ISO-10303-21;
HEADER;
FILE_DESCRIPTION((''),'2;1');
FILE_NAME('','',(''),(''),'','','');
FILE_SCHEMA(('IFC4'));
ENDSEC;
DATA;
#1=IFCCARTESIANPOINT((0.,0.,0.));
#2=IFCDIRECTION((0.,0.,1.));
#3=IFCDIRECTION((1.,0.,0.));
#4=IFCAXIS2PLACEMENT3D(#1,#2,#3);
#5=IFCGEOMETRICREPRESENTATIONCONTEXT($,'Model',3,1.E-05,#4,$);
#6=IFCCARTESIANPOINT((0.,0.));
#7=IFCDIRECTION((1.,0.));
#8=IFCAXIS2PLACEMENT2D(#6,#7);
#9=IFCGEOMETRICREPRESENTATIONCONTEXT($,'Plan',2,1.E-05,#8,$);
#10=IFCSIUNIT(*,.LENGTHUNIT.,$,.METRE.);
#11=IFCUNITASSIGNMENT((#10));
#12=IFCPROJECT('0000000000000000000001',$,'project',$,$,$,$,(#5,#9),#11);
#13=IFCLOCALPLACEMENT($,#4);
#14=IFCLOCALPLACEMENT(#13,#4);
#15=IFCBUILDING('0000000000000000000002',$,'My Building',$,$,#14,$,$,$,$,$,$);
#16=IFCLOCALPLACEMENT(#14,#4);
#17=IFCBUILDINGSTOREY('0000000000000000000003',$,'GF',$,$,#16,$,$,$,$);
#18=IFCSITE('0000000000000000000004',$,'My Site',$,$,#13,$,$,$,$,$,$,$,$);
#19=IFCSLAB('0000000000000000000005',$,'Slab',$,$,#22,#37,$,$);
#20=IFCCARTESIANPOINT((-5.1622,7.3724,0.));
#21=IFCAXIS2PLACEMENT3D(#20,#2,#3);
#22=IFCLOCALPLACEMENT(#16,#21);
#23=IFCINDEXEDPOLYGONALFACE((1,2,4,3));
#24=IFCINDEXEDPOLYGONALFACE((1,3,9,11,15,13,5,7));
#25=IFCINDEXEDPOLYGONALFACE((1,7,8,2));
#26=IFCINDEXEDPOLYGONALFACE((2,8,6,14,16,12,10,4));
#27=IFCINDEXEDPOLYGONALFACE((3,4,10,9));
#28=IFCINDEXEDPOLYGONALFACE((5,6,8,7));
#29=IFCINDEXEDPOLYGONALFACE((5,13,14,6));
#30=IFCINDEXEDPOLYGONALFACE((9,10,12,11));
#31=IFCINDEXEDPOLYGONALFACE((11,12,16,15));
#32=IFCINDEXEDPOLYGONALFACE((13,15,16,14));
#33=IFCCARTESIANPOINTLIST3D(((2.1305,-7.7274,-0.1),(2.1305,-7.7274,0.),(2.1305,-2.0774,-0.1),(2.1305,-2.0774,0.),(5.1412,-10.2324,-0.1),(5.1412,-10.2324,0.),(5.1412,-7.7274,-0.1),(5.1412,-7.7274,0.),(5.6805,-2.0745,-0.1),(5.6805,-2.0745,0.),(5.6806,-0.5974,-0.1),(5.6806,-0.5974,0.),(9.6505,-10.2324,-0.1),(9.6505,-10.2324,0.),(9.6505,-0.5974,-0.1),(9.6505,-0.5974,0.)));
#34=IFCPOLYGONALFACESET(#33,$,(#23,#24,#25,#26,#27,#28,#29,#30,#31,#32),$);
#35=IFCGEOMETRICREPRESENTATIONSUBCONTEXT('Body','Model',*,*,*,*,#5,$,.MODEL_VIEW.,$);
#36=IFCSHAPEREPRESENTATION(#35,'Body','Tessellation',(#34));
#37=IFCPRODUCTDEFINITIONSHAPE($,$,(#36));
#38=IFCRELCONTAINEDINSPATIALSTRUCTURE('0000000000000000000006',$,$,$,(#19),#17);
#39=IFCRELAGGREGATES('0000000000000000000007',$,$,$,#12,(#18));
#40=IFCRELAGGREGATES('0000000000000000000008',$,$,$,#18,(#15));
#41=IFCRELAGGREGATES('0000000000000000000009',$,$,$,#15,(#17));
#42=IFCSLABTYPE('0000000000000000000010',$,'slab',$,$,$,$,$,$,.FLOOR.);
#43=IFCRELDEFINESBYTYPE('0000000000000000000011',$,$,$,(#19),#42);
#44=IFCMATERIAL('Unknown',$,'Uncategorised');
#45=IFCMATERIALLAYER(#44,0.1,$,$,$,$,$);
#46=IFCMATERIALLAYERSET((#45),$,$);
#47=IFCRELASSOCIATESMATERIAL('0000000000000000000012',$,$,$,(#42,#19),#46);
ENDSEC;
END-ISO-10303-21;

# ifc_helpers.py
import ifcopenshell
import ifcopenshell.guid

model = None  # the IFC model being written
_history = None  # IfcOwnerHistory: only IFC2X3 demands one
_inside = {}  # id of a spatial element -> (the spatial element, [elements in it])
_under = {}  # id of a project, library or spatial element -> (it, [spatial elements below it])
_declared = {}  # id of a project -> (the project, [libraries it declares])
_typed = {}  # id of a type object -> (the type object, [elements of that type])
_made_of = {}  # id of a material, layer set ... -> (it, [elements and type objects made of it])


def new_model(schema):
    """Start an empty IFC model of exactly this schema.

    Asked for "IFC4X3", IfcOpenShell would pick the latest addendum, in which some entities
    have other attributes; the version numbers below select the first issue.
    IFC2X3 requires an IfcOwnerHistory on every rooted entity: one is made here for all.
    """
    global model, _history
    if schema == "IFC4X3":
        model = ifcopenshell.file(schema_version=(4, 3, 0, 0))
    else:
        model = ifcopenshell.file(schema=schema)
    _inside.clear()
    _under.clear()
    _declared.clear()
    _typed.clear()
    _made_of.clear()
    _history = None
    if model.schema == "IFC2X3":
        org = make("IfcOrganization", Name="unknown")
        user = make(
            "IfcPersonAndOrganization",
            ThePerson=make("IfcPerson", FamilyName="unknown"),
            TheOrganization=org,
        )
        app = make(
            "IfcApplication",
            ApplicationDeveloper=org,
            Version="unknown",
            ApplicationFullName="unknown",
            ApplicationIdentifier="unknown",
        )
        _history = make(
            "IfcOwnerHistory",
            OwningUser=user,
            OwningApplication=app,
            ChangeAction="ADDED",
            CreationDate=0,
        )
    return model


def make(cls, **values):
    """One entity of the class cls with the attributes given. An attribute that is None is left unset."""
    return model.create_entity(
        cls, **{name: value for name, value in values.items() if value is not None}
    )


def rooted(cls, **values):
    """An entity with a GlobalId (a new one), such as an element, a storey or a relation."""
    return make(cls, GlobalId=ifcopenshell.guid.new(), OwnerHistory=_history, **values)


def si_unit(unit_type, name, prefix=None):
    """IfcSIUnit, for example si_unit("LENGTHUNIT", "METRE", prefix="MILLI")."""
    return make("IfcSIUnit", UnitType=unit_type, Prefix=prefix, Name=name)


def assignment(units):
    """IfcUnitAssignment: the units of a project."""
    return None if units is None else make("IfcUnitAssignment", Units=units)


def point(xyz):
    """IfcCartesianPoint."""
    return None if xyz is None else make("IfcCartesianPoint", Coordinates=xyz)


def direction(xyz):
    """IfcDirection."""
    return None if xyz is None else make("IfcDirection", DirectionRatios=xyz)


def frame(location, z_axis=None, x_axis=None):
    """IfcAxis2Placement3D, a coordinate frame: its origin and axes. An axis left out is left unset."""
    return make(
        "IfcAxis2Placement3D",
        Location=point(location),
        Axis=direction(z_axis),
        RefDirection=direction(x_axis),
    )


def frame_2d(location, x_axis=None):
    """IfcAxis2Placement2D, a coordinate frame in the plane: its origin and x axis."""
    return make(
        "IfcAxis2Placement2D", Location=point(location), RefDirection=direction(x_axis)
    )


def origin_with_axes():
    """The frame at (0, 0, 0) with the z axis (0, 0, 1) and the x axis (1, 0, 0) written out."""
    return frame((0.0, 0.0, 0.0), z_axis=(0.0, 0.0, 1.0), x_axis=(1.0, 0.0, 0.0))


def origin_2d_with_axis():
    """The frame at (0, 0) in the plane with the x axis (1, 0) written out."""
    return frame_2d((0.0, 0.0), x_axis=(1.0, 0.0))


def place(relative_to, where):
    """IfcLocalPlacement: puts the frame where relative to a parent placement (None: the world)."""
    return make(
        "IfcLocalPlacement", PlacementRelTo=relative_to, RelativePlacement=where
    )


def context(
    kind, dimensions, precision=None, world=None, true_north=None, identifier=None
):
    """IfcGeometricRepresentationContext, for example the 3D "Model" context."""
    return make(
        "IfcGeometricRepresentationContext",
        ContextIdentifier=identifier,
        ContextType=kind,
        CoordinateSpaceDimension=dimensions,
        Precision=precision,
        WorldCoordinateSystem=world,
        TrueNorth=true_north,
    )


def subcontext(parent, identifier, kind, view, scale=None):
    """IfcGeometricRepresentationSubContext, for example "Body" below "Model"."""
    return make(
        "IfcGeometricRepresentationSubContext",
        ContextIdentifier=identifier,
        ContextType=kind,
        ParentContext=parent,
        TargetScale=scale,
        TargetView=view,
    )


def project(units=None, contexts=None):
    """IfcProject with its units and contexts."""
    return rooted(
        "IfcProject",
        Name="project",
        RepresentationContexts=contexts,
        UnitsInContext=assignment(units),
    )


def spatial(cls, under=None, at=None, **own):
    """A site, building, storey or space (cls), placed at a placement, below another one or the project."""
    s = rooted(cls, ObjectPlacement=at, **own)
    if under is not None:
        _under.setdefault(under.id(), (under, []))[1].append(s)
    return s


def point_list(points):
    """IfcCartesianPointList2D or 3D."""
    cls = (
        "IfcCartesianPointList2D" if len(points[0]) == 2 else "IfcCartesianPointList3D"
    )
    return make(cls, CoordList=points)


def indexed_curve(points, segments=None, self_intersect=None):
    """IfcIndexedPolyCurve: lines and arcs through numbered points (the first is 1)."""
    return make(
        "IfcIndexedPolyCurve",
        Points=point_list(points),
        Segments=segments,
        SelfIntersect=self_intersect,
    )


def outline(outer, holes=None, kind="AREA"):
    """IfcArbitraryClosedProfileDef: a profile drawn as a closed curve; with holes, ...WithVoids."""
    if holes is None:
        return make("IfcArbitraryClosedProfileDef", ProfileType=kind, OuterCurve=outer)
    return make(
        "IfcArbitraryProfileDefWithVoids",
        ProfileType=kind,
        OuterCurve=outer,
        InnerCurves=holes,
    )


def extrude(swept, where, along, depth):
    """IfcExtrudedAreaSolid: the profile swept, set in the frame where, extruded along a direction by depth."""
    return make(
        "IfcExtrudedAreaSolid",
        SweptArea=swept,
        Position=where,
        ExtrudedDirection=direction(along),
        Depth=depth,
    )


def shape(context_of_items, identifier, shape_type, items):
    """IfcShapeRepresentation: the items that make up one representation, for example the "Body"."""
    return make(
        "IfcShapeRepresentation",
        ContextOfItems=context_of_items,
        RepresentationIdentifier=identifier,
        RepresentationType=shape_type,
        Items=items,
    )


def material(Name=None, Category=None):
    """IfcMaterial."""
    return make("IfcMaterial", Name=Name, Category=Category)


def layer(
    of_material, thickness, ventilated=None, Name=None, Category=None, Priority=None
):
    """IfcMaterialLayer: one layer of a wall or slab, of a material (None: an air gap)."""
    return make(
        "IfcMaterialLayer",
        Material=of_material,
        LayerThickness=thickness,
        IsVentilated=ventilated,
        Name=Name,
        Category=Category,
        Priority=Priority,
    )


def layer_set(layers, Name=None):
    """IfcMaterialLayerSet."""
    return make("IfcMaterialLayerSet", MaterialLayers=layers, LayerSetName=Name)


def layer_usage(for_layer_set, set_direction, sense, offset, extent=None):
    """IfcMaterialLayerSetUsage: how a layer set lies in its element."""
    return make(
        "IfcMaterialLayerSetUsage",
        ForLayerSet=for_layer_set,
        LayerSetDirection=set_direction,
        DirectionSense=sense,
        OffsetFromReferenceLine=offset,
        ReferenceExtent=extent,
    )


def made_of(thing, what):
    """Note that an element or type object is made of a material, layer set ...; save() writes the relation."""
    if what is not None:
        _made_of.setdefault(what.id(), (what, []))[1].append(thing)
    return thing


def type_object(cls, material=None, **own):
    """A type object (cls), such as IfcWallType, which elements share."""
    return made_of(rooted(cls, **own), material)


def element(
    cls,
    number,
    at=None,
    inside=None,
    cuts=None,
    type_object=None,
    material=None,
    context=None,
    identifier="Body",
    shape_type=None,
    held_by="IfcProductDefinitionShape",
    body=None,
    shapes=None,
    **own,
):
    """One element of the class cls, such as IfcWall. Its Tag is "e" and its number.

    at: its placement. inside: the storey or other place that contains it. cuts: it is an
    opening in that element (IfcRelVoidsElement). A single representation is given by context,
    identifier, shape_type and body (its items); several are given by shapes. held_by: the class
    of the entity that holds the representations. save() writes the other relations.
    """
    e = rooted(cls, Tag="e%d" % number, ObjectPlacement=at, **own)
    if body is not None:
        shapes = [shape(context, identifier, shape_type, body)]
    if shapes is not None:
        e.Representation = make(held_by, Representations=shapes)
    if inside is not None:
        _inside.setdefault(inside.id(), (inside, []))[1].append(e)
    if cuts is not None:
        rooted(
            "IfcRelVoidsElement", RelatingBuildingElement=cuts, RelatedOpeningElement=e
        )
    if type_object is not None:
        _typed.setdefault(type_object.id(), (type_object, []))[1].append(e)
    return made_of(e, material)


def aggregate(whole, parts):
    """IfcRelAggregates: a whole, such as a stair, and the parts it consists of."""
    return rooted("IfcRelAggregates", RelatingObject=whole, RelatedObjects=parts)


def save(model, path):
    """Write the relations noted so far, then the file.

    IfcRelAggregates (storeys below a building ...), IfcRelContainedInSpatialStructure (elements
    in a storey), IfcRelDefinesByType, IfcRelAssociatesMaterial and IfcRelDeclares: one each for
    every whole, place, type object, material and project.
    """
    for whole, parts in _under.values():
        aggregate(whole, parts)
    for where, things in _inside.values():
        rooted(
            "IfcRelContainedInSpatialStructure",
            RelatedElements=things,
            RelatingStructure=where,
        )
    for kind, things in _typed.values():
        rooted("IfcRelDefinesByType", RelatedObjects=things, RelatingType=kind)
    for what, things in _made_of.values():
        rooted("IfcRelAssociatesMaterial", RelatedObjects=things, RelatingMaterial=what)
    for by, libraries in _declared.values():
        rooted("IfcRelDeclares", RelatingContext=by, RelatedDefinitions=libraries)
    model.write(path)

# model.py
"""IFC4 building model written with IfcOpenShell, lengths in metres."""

from ifc_helpers import new_model, si_unit, frame, origin_with_axes, origin_2d_with_axis, place, context, subcontext, project, spatial, indexed_curve, outline, extrude, material, layer, layer_set, layer_usage, type_object, element, save


model = new_model("IFC4")

# Units and contexts
model_context = context("Model", 3, precision=1e-05, world=origin_with_axes())
plan_context = context("Plan", 2, precision=1e-05, world=origin_2d_with_axis())
body_context_1 = subcontext(model_context, "Body", "Model", "MODEL_VIEW")
ifc_project = project(units=[si_unit("LENGTHUNIT", "METRE")], contexts=[model_context, plan_context])

# Site, building, storey
site_placement = place(None, origin_with_axes())
site = spatial("IfcSite", under=ifc_project, at=site_placement, Name="My Site")
building_placement = place(site_placement, origin_with_axes())
building = spatial("IfcBuilding", under=site, at=building_placement, Name="My Building")
storey_placement = place(building_placement, origin_with_axes())
storey = spatial("IfcBuildingStorey", under=building, at=storey_placement, Name="GF")

# Shared definitions
ifc_material = material(Name="Unknown", Category="Uncategorised")

# Slab
ifc_layer_1 = layer(ifc_material, 0.1)
ifc_layer_set_1 = layer_set([ifc_layer_1])
ifc_layer_usage_1 = layer_usage(ifc_layer_set_1, "AXIS3", "POSITIVE", -0.1)
slab_type = type_object("IfcSlabType", Name="slab", PredefinedType="FLOOR", material=ifc_layer_set_1)
slab_placement = place(storey_placement, frame((-5.1622, 7.3724, 0.0), z_axis=(0.0, 0.0, 1.0), x_axis=(1.0, 0.0, 0.0)))
element("IfcSlab", 1, at=slab_placement, inside=storey, type_object=slab_type, material=ifc_layer_usage_1, Name="Slab", context=body_context_1, shape_type="SweptSolid", body=[
    extrude(outline(indexed_curve([(2.1305, -2.0774), (2.1305, -7.7274), (5.1412, -7.7274), (5.1412, -10.2324), (9.6505, -10.2324), (9.6505, -0.5974), (5.6806, -0.5974), (5.6805, -2.0745), (2.1305, -2.0774)])), frame((0.0, 0.0, -0.1), z_axis=(0.0, 0.0, 1.0), x_axis=(1.0, 0.0, 0.0)), (0.0, 0.0, 1.0), 0.1),
])

save(model, "model.ifc")
